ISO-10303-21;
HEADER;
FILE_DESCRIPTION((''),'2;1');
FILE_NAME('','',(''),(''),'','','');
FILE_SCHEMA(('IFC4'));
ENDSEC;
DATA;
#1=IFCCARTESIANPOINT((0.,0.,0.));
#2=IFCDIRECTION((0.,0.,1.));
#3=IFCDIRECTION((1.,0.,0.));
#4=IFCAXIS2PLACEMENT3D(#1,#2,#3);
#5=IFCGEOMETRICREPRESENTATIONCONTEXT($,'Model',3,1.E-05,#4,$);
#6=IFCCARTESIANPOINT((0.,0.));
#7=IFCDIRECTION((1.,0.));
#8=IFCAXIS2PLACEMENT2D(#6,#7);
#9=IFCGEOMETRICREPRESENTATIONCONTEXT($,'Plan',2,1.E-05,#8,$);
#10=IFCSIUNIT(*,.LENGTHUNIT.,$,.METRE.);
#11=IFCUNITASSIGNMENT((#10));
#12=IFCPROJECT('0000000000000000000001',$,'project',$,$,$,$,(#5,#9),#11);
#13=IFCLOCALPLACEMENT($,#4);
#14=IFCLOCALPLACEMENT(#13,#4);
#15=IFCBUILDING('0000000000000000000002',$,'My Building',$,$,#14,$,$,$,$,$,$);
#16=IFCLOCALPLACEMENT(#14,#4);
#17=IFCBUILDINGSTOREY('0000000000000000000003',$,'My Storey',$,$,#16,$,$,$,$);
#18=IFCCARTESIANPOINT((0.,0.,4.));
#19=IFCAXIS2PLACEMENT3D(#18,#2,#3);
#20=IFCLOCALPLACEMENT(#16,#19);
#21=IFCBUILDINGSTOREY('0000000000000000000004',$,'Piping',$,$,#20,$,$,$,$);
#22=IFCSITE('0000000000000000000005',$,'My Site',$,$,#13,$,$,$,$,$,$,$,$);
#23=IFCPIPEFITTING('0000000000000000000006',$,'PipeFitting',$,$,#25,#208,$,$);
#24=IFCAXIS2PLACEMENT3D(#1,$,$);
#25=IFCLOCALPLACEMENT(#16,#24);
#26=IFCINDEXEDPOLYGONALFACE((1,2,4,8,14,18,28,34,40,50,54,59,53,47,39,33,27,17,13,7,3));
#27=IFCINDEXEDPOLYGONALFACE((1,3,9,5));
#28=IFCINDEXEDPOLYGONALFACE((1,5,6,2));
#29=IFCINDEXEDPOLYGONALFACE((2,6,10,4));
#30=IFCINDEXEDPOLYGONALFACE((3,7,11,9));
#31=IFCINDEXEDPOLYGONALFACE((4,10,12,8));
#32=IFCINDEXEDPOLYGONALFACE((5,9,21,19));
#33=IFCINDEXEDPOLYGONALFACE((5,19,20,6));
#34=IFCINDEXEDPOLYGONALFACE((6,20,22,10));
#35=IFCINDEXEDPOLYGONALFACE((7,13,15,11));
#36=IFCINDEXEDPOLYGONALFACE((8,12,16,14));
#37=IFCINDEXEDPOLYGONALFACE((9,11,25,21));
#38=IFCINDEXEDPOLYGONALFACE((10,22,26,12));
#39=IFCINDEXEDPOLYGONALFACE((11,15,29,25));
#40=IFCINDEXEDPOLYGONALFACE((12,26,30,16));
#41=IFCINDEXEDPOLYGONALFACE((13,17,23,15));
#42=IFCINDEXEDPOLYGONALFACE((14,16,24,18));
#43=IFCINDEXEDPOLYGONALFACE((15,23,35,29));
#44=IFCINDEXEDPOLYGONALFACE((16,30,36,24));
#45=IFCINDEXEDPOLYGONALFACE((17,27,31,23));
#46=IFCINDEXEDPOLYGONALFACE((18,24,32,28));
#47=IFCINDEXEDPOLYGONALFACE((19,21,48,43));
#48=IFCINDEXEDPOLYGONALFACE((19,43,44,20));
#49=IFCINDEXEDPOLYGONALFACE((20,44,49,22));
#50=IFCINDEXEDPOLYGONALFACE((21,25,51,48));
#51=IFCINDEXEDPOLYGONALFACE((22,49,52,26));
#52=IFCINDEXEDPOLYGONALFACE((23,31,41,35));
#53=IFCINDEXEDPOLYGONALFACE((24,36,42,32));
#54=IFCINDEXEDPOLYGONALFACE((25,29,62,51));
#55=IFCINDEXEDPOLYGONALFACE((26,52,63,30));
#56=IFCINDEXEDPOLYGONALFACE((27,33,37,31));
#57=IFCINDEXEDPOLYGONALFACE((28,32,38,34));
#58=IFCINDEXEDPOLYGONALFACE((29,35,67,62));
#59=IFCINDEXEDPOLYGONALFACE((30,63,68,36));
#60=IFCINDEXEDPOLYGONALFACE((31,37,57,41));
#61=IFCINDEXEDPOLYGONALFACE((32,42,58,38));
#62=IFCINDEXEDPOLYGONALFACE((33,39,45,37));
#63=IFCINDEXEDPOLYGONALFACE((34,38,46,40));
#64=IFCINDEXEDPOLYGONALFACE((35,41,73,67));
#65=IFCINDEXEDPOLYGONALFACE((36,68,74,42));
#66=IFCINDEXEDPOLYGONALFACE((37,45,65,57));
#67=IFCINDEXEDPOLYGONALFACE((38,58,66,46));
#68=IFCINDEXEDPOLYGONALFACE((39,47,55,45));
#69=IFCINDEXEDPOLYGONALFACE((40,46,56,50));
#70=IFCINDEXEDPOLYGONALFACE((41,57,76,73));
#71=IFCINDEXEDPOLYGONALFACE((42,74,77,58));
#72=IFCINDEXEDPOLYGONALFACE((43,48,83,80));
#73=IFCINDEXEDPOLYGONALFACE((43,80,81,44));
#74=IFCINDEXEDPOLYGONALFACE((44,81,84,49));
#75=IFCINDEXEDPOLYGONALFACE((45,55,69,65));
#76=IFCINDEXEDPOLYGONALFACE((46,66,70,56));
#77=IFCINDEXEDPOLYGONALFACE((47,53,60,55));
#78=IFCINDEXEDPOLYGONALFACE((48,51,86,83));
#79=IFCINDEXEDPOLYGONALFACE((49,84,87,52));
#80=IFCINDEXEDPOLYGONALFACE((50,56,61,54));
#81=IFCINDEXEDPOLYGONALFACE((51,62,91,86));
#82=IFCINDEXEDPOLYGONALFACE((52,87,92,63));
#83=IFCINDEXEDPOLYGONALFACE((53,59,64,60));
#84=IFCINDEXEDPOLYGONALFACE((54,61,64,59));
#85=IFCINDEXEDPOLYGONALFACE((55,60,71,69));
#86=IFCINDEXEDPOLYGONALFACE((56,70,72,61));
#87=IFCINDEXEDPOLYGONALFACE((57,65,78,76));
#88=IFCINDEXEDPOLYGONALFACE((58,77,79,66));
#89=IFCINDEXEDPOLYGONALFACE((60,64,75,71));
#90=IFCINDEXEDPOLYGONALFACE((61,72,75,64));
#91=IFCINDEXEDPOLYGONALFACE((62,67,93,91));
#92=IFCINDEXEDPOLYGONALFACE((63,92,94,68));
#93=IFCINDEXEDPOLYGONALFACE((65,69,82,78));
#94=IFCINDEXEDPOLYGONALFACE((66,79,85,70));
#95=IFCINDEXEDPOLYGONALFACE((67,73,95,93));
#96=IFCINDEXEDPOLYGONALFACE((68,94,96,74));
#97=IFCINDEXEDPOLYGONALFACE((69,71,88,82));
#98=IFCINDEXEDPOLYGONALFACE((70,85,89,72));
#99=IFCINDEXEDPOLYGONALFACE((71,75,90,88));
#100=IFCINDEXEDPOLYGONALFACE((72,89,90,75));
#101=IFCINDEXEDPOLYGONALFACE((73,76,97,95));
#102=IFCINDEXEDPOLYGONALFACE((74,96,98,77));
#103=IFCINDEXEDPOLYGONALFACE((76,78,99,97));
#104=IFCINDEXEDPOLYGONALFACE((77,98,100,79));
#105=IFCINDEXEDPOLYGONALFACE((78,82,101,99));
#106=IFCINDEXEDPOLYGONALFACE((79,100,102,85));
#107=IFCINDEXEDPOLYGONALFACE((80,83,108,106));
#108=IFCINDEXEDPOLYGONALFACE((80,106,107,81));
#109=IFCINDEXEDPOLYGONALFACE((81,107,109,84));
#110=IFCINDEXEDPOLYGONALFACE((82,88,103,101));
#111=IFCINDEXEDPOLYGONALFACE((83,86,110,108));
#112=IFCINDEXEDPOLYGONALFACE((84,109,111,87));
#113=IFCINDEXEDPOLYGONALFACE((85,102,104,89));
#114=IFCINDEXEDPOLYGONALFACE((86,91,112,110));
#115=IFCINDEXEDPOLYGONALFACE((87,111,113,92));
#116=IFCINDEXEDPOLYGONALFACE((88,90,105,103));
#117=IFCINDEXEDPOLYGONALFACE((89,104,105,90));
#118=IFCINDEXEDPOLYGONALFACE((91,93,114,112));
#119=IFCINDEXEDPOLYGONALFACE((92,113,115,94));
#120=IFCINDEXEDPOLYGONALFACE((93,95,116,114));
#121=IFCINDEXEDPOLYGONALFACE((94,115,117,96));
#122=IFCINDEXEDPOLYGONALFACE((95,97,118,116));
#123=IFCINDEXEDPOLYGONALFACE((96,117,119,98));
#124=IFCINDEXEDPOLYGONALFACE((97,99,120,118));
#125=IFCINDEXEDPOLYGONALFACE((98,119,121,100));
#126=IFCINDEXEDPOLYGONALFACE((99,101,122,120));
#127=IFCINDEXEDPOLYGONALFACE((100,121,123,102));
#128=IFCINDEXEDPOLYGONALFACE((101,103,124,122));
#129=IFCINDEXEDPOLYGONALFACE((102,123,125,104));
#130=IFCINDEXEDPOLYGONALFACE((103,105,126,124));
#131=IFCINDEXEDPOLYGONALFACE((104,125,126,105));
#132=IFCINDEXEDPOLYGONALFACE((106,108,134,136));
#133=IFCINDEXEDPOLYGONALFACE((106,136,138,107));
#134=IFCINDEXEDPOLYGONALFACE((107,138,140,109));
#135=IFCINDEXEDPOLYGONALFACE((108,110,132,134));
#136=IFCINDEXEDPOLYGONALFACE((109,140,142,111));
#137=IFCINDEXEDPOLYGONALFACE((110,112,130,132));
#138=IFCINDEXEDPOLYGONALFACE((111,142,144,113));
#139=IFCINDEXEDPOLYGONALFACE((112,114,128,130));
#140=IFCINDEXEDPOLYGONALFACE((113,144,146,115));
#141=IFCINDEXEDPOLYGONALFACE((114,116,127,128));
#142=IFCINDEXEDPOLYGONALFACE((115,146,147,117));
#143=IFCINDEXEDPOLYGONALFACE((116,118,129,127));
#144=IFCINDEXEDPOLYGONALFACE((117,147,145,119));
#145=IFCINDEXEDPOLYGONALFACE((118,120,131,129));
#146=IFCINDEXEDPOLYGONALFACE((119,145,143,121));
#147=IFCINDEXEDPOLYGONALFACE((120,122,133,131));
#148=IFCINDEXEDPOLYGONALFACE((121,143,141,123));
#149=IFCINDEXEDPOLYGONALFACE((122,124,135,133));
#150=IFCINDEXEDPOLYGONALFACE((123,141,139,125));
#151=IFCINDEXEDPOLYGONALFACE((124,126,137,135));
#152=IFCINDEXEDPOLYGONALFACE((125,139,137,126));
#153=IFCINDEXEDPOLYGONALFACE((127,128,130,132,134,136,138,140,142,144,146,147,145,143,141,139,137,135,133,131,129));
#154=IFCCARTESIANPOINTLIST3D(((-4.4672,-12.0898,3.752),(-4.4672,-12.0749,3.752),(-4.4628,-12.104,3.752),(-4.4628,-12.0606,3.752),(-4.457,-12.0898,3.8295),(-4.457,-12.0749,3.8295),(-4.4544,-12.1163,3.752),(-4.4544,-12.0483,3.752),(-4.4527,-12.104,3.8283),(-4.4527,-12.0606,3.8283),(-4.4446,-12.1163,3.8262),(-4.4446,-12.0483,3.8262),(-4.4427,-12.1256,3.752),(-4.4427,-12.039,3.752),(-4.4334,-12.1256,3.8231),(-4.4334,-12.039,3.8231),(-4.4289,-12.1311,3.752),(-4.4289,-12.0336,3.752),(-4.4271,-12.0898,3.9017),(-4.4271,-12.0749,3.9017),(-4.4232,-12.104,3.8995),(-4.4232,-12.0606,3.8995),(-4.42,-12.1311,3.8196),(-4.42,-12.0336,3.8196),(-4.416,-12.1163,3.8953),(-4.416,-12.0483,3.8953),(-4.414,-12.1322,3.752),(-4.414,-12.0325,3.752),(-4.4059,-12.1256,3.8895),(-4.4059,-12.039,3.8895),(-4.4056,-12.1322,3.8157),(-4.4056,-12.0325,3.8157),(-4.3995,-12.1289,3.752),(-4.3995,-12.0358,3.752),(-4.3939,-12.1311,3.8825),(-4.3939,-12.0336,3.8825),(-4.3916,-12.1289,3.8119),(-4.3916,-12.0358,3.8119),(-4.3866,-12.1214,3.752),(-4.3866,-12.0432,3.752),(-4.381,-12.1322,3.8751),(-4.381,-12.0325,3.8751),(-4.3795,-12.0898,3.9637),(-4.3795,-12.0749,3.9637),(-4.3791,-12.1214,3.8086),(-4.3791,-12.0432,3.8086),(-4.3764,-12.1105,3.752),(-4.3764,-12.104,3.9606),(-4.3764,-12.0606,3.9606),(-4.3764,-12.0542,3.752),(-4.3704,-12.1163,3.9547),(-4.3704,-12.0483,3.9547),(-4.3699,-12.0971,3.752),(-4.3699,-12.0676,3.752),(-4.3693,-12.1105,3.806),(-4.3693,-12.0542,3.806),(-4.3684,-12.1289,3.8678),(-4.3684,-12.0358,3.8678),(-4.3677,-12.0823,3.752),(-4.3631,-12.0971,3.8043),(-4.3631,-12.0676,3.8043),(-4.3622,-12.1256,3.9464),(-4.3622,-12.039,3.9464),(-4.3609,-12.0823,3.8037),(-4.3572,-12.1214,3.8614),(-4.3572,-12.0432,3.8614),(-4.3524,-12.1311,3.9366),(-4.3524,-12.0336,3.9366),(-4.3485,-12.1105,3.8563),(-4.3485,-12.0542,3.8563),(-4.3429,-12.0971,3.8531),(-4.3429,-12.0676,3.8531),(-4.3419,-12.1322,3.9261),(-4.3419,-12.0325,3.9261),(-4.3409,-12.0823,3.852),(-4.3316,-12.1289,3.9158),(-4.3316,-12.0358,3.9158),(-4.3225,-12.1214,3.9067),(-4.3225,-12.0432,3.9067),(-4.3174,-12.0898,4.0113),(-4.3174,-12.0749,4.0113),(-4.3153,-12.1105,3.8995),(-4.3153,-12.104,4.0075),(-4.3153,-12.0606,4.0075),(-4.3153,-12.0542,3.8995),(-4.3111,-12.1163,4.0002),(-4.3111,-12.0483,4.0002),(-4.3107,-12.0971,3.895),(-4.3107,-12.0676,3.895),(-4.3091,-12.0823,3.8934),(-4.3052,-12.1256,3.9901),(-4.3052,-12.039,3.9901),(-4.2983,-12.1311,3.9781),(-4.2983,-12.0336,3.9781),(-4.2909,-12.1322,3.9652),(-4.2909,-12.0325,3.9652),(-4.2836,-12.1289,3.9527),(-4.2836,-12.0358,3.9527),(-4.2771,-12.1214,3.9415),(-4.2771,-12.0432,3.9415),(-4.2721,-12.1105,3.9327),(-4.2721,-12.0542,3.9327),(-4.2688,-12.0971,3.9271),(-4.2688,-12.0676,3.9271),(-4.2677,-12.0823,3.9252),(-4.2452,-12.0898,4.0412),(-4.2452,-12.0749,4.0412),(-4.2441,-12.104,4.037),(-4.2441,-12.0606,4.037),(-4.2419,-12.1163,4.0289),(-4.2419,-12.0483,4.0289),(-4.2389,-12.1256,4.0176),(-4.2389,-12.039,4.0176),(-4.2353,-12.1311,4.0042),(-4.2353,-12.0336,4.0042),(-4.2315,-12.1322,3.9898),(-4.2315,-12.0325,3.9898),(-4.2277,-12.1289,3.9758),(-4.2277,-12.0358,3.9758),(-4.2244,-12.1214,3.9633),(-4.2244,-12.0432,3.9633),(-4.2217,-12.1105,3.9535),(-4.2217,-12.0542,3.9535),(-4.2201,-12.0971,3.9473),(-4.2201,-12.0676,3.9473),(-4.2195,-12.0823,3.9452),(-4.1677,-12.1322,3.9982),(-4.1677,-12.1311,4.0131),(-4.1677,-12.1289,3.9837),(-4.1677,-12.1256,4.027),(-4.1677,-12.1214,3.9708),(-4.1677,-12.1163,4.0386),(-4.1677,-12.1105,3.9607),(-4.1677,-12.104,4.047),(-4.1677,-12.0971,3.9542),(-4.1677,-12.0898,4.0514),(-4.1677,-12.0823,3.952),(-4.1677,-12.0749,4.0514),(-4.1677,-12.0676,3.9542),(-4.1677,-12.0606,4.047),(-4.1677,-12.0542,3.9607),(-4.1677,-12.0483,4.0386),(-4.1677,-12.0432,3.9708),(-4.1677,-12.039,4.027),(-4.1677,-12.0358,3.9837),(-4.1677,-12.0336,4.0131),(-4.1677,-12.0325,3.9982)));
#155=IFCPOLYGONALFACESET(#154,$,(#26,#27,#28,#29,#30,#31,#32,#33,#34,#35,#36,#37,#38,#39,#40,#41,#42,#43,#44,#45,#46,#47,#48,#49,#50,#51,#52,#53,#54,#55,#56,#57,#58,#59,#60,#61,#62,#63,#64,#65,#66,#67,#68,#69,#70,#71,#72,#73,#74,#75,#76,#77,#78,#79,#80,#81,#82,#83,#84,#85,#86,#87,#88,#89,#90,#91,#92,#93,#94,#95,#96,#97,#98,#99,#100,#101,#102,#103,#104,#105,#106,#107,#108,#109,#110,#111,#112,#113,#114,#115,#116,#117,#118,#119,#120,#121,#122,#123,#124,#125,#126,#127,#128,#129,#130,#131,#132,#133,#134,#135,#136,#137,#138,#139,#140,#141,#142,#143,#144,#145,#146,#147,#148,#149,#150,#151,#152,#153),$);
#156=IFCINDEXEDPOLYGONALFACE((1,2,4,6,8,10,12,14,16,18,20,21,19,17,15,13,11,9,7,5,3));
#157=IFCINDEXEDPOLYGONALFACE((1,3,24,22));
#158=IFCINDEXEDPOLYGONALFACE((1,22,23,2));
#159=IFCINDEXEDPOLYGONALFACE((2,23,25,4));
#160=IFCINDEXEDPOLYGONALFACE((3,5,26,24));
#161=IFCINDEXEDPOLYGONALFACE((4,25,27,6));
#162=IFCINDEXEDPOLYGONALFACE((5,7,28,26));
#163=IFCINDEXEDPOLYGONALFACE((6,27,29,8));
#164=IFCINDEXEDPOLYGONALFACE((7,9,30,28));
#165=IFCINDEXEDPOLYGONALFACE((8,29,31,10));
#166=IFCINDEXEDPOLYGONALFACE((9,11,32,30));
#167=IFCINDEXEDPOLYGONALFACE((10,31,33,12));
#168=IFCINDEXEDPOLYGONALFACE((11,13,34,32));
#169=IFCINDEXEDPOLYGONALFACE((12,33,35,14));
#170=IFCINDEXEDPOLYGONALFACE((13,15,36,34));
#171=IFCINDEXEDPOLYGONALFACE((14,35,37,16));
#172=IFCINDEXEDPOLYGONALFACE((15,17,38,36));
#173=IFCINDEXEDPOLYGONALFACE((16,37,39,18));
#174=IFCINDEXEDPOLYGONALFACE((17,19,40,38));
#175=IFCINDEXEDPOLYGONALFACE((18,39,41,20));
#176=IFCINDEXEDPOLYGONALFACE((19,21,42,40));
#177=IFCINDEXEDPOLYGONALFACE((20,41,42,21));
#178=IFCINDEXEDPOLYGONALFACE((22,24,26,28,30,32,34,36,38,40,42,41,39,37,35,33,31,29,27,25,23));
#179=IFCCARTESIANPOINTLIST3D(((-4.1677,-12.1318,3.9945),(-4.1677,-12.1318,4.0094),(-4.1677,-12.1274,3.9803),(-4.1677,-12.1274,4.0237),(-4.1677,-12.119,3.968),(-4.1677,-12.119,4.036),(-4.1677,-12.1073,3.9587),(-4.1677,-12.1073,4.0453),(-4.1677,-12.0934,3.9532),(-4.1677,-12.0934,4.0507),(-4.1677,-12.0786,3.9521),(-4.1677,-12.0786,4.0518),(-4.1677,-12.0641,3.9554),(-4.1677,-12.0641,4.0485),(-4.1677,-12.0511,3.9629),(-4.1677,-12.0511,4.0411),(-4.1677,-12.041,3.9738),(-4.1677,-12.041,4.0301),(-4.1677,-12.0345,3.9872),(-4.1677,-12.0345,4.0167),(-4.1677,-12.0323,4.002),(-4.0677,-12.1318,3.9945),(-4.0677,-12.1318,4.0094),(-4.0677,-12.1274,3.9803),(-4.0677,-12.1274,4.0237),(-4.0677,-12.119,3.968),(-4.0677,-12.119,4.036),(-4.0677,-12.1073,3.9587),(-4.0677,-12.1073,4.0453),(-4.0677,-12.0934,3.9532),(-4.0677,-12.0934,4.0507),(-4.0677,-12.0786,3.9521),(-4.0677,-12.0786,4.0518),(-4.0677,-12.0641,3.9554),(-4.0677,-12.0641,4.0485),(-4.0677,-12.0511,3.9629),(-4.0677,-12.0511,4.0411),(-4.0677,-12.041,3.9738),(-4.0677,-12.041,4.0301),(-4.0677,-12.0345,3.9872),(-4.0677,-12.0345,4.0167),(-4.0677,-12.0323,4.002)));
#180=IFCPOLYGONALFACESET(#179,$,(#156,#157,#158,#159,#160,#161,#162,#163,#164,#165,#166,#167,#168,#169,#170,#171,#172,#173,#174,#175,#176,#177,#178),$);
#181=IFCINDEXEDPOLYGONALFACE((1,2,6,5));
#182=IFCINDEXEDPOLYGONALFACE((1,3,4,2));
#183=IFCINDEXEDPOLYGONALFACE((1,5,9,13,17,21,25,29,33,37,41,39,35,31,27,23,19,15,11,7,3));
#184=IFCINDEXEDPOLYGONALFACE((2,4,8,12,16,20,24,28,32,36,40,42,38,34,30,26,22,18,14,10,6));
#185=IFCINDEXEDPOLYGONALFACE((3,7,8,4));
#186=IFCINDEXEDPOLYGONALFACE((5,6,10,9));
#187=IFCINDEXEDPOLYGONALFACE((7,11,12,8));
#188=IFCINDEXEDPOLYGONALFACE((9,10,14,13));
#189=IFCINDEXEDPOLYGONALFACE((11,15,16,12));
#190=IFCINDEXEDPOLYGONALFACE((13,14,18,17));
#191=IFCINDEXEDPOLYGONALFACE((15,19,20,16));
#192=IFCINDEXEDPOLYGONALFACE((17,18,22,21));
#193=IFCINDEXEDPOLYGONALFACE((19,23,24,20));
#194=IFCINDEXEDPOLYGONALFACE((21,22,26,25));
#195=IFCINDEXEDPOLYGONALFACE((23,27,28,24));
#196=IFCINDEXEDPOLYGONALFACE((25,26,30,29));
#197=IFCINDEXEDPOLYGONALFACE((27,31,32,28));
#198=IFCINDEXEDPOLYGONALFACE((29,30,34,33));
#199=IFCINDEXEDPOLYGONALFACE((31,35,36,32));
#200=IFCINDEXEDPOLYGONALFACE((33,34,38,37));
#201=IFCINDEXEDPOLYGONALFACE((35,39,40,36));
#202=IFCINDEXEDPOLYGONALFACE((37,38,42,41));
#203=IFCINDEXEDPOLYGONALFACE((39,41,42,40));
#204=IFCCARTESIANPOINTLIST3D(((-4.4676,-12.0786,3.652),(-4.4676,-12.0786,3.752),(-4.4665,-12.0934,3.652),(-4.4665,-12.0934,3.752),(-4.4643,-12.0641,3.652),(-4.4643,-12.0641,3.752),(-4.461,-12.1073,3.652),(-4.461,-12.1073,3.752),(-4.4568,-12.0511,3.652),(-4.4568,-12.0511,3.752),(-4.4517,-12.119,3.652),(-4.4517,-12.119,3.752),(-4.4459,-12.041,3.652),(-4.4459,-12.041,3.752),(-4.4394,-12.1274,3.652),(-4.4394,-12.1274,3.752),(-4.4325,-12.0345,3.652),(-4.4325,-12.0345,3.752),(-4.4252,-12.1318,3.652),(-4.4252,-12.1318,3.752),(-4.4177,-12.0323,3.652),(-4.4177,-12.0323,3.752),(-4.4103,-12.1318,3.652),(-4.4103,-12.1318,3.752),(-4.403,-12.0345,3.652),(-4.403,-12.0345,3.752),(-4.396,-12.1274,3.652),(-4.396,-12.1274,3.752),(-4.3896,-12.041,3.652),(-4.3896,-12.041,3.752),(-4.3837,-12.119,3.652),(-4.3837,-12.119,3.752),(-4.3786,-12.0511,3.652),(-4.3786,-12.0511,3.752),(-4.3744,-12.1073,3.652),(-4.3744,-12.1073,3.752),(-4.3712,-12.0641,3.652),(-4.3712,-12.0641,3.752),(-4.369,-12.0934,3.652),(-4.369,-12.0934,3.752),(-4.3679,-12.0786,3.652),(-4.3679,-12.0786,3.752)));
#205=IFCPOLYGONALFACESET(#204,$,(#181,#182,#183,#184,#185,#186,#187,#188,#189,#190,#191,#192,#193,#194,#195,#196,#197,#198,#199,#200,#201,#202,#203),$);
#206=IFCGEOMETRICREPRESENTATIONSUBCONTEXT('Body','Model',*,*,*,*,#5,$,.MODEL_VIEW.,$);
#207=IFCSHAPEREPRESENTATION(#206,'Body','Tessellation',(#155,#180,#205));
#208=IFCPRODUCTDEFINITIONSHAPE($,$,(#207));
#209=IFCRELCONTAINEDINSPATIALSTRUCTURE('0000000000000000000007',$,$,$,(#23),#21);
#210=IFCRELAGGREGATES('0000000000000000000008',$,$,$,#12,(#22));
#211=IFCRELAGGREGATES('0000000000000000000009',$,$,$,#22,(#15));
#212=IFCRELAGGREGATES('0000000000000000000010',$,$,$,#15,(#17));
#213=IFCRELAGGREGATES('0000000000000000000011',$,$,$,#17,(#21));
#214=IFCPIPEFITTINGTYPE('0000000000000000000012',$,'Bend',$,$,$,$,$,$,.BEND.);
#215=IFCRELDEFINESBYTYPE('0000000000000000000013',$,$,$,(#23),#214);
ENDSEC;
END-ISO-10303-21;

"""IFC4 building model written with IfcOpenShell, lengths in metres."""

from ifc_helpers import new_model, entity, si_unit, frame, origin_with_axes, origin_2d_with_axis, place, context, subcontext, project, spatial, line, indexed_curve, circle, outline, extrude, source, transform, mapped, type_object, type_shapes, element, save


model = new_model("IFC4")

# Units and contexts
model_context = context("Model", 3, precision=1e-05, world=origin_with_axes())
plan_context = context("Plan", 2, precision=1e-05, world=origin_2d_with_axis())
body_context = subcontext(model_context, "Body", "Model", "MODEL_VIEW")
ifc_project = project(units=[si_unit("LENGTHUNIT", "METRE")], contexts=[model_context, plan_context])

# Site, building, storeys
site_placement = place(None, origin_with_axes())
site = spatial("IfcSite", under=ifc_project, at=site_placement, Name="My Site")
building_placement = place(site_placement, origin_with_axes())
building = spatial("IfcBuilding", under=site, at=building_placement, Name="My Building")
storey_1_placement = place(building_placement, origin_with_axes())
storey_1 = spatial("IfcBuildingStorey", under=building, at=storey_1_placement, Name="My Storey")
storey_2_placement = place(storey_1_placement, frame((0.0, 0.0, 4.0), z_axis=(0.0, 0.0, 1.0), x_axis=(1.0, 0.0, 0.0)))
storey_2 = spatial("IfcBuildingStorey", under=storey_1, at=storey_2_placement, Name="Piping")

# Shared definitions
pipe_fitting_type_1 = type_object("IfcPipeFittingType", Name="Bend", PredefinedType="BEND")
shared_shape = source(origin_with_axes(), body_context, "Body", "SolidModel", [
    entity("IfcSweptDiskSolid", entity("IfcIndexedPolyCurve", entity("IfcCartesianPointList3D", [[0.0, 0.0, -0.1], [0.0, -0.0732, -0.2768], [0.0, -0.25, -0.35]]), [entity("IfcArcIndex", [1, 2, 3])]), 0.05),
    extrude(circle(Radius=0.05), origin_with_axes(), (0.0, 0.0, -1.0), 0.1),
    extrude(circle(Radius=0.05), frame((0.0, -0.25, -0.35), z_axis=(0.0, -1.0, 0.0), x_axis=(1.0, 0.0, 0.0)), (0.0, 0.0, 1.0), 0.1),
])
type_shapes(pipe_fitting_type_1, [shared_shape])

# Pipe fitting, opening
pipe_fitting_1_placement = place(storey_2_placement, frame((-4.0677, -12.0823, 0.002), z_axis=(1.0, 0.0, 0.0), x_axis=(0.0, 1.0, 0.0)))
pipe_fitting_1 = element("IfcPipeFitting", 1, at=pipe_fitting_1_placement, inside=storey_2, type_object=pipe_fitting_type_1, Name="PipeFitting", context=body_context, shape_type="MappedRepresentation", body=[
    mapped(shared_shape, transform((0.0, 0.0, 0.0), x_axis=(1.0, 0.0, 0.0), y_axis=(0.0, 1.0, 0.0), z_axis=(0.0, 0.0, 1.0), scale=1.0)),
])
opening_1_placement = place(pipe_fitting_1_placement, frame((12.0823, -4.002, 4.0677), z_axis=(0.0, 1.0, 0.0), x_axis=(0.0, 0.0, 1.0)))
element("IfcOpeningElement", 2, at=opening_1_placement, cuts=pipe_fitting_1, PredefinedType="OPENING", context=body_context, shape_type="SweptSolid", body=[
    extrude(outline(indexed_curve([(0.0, 0.0), (0.5, 0.0), (0.5, 0.5), (0.0, 0.5)], segments=[line(1, 2, 3, 4, 1)])), origin_with_axes(), (0.0, 0.0, 1.0), 0.5),
])

save(model, "model.ifc")
